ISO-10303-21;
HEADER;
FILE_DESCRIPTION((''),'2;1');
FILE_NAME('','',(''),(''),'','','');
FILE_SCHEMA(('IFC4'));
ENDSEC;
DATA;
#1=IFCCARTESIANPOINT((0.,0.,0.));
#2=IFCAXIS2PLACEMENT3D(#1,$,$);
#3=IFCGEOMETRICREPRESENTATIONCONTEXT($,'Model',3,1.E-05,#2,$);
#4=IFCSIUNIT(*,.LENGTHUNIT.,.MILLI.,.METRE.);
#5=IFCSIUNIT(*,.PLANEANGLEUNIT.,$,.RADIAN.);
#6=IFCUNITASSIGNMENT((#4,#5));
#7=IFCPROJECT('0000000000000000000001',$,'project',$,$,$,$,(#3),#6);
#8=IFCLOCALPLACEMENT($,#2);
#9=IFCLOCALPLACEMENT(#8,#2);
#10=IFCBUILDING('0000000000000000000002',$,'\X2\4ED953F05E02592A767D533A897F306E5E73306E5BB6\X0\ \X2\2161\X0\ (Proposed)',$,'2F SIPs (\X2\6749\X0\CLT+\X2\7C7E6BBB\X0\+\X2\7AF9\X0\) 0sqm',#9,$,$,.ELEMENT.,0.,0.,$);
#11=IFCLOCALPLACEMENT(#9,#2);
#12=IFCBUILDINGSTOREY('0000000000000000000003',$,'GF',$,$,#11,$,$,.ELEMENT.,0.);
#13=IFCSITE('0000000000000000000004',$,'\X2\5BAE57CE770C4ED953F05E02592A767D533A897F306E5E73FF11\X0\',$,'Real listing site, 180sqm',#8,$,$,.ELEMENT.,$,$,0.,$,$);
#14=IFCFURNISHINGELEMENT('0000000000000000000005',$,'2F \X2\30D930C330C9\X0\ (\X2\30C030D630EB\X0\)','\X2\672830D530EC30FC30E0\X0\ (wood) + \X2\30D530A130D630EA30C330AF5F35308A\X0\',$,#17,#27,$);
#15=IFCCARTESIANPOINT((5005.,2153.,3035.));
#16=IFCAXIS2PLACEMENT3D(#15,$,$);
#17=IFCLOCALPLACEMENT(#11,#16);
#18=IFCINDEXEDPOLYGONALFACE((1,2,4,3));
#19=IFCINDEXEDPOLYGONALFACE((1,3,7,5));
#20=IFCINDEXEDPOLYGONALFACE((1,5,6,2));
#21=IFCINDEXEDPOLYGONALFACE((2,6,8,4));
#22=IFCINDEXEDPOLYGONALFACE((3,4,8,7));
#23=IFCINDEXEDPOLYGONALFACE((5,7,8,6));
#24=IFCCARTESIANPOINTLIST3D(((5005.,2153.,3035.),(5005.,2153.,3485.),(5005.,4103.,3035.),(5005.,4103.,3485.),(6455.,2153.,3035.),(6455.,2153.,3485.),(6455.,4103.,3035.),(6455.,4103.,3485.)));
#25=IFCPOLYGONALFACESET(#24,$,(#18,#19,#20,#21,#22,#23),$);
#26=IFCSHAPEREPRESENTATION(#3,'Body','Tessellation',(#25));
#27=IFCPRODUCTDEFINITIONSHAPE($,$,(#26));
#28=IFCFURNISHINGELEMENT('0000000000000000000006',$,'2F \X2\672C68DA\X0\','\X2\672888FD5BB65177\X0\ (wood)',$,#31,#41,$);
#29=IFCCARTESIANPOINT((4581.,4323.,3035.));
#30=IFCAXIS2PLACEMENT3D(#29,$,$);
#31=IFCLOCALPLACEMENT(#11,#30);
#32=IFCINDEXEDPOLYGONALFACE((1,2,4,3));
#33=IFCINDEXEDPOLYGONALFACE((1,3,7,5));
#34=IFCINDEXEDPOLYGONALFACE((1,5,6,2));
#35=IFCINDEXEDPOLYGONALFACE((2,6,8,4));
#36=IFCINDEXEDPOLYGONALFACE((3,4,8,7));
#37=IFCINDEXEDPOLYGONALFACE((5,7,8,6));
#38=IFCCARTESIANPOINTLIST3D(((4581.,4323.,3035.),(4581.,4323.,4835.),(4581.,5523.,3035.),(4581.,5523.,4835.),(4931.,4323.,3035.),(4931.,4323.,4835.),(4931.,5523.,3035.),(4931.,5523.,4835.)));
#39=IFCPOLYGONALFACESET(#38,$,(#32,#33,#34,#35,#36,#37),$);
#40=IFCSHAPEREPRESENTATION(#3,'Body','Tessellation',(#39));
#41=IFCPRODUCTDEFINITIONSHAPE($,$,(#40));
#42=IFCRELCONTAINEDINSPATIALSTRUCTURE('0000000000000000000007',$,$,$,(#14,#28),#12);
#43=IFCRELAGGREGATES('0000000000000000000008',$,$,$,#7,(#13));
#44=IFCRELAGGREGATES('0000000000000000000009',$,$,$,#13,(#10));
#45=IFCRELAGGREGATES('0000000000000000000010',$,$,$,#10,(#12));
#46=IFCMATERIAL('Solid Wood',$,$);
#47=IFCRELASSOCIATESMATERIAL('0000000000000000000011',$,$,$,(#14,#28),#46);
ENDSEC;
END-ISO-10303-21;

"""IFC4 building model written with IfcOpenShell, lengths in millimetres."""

from ifc_helpers import new_model, si_unit, frame, frame_2d, origin, place, context, project, spatial, rectangle, extrude, material, element, save


model = new_model("IFC4")

# Units and contexts
model_context = context("Model", 3, precision=1e-05, world=origin())
ifc_project = project(units=[si_unit("LENGTHUNIT", "METRE", prefix="MILLI"), si_unit("PLANEANGLEUNIT", "RADIAN")], contexts=[model_context])

# Site, building, storey
site_placement = place(None, origin())
site = spatial("IfcSite", under=ifc_project, at=site_placement, Name="宮城県仙台市太白区西の平１", ObjectType="Real listing site, 180sqm", CompositionType="ELEMENT", RefElevation=0.0)
building_placement = place(site_placement, origin())
building = spatial("IfcBuilding", under=site, at=building_placement, Name="仙台市太白区西の平の家 Ⅱ (Proposed)", ObjectType="2F SIPs (杉CLT+籾殻+竹) 0sqm", CompositionType="ELEMENT", ElevationOfRefHeight=0.0, ElevationOfTerrain=0.0)
storey_placement = place(building_placement, origin())
storey = spatial("IfcBuildingStorey", under=building, at=storey_placement, Name="GF", CompositionType="ELEMENT", Elevation=0.0)

# Shared definitions
ifc_material_1 = material(Name="Solid Wood")

# Furnishing elements
furnishing_1_placement = place(storey_placement, frame((5005.0, 2153.0, 3035.0)))
element("IfcFurnishingElement", 1, at=furnishing_1_placement, inside=storey, material=ifc_material_1, Name="2F ベッド (ダブル)", Description="木フレーム (wood) + ファブリック張り", context=model_context, shape_type="SweptSolid", body=[
    extrude(rectangle(XDim=1450.0, YDim=1950.0, at=frame_2d((725.0, 975.0))), frame((5005.0, 2153.0, 3035.0)), (0.0, 0.0, 1.0), 450.0),
])
furnishing_2_placement = place(storey_placement, frame((4581.0, 4323.0, 3035.0)))
element("IfcFurnishingElement", 2, at=furnishing_2_placement, inside=storey, material=ifc_material_1, Name="2F 本棚", Description="木製家具 (wood)", context=model_context, shape_type="SweptSolid", body=[
    extrude(rectangle(XDim=350.0, YDim=1200.0, at=frame_2d((175.0, 600.0))), frame((4581.0, 4323.0, 3035.0)), (0.0, 0.0, 1.0), 1800.0),
])

save(model, "model.ifc")
